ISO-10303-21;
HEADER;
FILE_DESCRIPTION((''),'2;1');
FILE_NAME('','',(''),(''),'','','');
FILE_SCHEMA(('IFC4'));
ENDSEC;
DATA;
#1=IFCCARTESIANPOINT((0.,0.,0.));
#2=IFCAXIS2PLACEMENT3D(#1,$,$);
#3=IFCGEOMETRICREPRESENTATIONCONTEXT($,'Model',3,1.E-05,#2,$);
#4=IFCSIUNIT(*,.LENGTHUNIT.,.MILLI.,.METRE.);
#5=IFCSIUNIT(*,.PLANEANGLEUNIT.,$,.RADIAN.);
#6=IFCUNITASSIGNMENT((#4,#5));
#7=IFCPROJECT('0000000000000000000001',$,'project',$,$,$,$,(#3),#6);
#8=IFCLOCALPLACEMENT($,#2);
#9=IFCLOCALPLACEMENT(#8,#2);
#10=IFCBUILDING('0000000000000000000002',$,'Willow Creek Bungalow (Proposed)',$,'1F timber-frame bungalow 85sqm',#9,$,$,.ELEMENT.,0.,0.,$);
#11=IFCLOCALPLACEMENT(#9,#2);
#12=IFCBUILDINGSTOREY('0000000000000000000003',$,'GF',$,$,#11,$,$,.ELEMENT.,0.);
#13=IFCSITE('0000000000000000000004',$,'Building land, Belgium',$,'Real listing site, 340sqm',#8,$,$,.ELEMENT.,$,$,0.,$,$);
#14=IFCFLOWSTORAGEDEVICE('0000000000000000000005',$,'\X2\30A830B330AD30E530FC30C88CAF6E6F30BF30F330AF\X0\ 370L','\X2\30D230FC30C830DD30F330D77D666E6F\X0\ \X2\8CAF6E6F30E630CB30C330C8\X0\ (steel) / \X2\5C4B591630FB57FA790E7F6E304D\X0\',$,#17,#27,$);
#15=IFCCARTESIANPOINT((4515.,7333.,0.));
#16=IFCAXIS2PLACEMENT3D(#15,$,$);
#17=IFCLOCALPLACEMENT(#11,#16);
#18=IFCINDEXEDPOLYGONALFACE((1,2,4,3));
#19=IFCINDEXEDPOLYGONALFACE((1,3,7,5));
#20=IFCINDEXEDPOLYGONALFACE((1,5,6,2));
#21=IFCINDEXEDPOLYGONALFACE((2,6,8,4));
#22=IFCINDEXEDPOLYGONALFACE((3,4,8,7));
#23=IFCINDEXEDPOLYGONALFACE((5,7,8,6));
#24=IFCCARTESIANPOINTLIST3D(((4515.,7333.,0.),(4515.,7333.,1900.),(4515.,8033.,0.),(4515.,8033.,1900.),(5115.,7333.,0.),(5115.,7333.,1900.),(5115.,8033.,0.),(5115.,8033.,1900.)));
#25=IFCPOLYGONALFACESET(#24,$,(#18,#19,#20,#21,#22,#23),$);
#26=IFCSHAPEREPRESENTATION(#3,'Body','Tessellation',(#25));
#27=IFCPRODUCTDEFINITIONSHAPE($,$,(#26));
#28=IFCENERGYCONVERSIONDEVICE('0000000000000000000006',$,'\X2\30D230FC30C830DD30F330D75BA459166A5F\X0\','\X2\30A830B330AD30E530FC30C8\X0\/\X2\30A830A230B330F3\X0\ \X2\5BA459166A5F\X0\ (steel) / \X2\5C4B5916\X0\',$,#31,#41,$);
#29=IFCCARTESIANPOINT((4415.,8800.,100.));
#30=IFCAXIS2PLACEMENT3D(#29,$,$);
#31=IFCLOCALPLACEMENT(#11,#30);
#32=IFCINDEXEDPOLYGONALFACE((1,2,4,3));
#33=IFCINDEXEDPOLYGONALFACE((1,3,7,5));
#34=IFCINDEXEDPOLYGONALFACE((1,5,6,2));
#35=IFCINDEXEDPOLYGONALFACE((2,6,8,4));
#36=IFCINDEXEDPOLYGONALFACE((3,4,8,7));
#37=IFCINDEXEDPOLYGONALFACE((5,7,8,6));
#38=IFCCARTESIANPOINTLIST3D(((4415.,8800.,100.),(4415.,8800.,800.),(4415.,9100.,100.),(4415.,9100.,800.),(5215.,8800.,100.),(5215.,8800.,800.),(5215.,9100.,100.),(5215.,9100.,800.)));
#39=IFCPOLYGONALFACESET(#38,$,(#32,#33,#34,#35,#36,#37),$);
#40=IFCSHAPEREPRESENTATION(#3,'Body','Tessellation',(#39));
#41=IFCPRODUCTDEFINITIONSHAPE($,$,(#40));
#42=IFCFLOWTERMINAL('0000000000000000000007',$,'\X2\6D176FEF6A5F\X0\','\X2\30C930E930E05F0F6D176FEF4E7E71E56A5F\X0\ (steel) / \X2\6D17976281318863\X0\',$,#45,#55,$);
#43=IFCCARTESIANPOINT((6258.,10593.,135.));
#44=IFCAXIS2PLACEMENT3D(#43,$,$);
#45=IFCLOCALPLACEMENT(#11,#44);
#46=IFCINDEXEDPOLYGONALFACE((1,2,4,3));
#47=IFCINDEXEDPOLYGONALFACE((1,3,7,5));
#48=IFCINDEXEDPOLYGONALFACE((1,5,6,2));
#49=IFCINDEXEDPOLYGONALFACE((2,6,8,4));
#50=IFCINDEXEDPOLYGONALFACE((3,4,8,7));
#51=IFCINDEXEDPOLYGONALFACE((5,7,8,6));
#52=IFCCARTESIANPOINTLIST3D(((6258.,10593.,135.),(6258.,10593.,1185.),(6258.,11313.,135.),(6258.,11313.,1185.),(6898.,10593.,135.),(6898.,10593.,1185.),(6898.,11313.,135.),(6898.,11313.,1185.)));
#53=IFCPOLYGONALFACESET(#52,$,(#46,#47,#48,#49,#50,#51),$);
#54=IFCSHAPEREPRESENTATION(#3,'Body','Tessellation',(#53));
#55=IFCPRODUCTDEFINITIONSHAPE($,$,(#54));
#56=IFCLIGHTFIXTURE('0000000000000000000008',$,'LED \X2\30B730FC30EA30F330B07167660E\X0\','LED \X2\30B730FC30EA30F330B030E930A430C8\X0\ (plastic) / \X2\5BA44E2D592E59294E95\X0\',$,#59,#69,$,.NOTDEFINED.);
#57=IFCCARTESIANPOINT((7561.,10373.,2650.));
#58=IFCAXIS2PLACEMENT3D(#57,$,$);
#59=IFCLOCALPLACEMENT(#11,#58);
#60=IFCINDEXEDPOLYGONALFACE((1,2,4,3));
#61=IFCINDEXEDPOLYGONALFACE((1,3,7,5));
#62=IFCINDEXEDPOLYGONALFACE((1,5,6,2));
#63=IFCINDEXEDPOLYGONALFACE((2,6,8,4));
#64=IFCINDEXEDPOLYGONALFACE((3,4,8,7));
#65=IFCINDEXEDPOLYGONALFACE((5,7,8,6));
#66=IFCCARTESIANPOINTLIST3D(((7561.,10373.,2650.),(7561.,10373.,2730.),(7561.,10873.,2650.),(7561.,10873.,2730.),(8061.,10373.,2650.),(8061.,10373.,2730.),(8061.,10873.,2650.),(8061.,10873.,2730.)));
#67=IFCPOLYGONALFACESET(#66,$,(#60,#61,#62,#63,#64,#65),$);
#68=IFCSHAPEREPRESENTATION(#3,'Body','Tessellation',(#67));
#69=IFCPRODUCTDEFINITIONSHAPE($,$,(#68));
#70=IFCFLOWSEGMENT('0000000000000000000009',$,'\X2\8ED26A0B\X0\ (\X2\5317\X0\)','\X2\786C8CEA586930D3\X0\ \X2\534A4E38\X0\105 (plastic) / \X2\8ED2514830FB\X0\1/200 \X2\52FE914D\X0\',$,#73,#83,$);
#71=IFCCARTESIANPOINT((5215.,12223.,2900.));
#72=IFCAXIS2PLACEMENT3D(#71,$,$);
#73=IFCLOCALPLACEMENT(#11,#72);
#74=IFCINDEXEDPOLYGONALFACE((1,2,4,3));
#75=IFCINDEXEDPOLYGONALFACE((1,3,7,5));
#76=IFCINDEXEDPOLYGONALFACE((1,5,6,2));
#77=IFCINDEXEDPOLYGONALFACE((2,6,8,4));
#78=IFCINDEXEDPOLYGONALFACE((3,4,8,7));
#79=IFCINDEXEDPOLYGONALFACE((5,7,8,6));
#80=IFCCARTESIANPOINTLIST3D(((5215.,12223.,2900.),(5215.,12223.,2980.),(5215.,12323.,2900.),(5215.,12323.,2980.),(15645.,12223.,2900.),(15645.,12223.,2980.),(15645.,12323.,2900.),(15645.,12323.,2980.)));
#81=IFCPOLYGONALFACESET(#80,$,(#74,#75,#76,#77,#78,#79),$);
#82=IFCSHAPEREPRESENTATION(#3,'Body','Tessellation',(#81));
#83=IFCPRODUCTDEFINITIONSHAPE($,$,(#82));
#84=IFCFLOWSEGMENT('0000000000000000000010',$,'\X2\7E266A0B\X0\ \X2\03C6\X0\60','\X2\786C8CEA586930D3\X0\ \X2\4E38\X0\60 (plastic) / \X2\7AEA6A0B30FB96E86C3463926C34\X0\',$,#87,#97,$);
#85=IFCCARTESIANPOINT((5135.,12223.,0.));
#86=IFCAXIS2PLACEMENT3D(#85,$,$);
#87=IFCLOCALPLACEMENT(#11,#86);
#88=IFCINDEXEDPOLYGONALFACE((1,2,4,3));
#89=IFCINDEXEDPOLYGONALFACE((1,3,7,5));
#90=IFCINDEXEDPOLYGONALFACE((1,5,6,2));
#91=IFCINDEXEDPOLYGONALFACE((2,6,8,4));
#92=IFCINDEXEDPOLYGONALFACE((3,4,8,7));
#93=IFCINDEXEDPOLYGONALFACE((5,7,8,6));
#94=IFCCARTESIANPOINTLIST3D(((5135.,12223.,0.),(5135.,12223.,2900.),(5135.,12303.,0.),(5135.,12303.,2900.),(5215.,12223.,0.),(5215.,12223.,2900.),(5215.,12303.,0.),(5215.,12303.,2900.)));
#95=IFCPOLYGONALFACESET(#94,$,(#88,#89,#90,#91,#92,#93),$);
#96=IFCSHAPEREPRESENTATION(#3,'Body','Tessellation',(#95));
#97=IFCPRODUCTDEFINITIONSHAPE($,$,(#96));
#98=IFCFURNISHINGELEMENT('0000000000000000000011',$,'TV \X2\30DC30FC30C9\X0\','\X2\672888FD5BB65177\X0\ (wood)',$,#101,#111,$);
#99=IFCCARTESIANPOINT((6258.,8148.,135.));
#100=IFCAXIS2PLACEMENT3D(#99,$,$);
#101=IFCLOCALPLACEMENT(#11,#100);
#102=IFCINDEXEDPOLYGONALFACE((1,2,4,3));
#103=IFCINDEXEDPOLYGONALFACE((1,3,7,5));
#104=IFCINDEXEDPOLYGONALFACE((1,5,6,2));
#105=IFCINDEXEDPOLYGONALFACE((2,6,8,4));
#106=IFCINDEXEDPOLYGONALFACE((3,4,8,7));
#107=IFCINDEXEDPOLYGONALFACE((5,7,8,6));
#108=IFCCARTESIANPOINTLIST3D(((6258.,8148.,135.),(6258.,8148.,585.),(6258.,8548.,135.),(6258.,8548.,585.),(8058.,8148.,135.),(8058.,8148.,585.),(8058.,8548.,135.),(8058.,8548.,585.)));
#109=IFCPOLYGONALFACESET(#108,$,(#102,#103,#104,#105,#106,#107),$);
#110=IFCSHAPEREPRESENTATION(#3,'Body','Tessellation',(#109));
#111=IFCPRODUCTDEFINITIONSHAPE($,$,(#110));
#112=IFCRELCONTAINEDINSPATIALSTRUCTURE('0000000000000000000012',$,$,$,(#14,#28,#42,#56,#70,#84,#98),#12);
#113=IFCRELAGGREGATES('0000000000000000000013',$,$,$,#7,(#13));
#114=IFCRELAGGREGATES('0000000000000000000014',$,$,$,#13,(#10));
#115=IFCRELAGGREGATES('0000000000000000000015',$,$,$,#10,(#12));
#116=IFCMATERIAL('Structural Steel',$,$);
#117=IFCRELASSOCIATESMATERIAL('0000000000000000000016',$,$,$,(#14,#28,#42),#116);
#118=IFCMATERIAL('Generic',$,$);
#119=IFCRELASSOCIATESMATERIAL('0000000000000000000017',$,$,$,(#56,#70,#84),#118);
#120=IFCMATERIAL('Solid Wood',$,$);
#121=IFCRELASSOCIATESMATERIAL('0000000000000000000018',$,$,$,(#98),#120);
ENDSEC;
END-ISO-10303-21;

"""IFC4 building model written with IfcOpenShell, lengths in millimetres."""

from ifc_helpers import new_model, si_unit, frame, frame_2d, origin, place, context, project, spatial, rectangle, extrude, material, element, save


model = new_model("IFC4")

# Units and contexts
model_context = context("Model", 3, precision=1e-05, world=origin())
ifc_project = project(units=[si_unit("LENGTHUNIT", "METRE", prefix="MILLI"), si_unit("PLANEANGLEUNIT", "RADIAN")], contexts=[model_context])

# Site, building, storey
site_placement = place(None, origin())
site = spatial("IfcSite", under=ifc_project, at=site_placement, Name="Building land, Belgium", ObjectType="Real listing site, 340sqm", CompositionType="ELEMENT", RefElevation=0.0)
building_placement = place(site_placement, origin())
building = spatial("IfcBuilding", under=site, at=building_placement, Name="Willow Creek Bungalow (Proposed)", ObjectType="1F timber-frame bungalow 85sqm", CompositionType="ELEMENT", ElevationOfRefHeight=0.0, ElevationOfTerrain=0.0)
storey_placement = place(building_placement, origin())
storey = spatial("IfcBuildingStorey", under=building, at=storey_placement, Name="GF", CompositionType="ELEMENT", Elevation=0.0)

# Shared definitions
ifc_material_1 = material(Name="Solid Wood")

# Shared definitions
ifc_material_2 = material(Name="Structural Steel")

# Shared definitions
ifc_material_3 = material(Name="Generic")

# Flow storage device
flow_storage_device_placement = place(storey_placement, frame((4515.0, 7333.0, 0.0)))
element("IfcFlowStorageDevice", 1, at=flow_storage_device_placement, inside=storey, material=ifc_material_2, Name="エコキュート貯湯タンク 370L", Description="ヒートポンプ給湯 貯湯ユニット (steel) / 屋外・基礎置き", context=model_context, shape_type="SweptSolid", body=[
    extrude(rectangle(XDim=600.0, YDim=700.0, at=frame_2d((300.0, 350.0))), frame((4515.0, 7333.0, 0.0)), (0.0, 0.0, 1.0), 1900.0),
])

# Energy conversion device
energy_conversion_device_placement = place(storey_placement, frame((4415.0, 8800.0, 100.0)))
element("IfcEnergyConversionDevice", 2, at=energy_conversion_device_placement, inside=storey, material=ifc_material_2, Name="ヒートポンプ室外機", Description="エコキュート/エアコン 室外機 (steel) / 屋外", context=model_context, shape_type="SweptSolid", body=[
    extrude(rectangle(XDim=800.0, YDim=300.0, at=frame_2d((400.0, 150.0))), frame((4415.0, 8800.0, 100.0)), (0.0, 0.0, 1.0), 700.0),
])

# Flow terminal
flow_terminal_placement = place(storey_placement, frame((6258.0, 10593.0, 135.0)))
element("IfcFlowTerminal", 3, at=flow_terminal_placement, inside=storey, material=ifc_material_2, Name="洗濯機", Description="ドラム式洗濯乾燥機 (steel) / 洗面脱衣", context=model_context, shape_type="SweptSolid", body=[
    extrude(rectangle(XDim=640.0, YDim=720.0, at=frame_2d((320.0, 360.0))), frame((6258.0, 10593.0, 135.0)), (0.0, 0.0, 1.0), 1050.0),
])

# Light fixture
light_fixture_placement = place(storey_placement, frame((7561.0, 10373.0, 2650.0)))
element("IfcLightFixture", 4, at=light_fixture_placement, inside=storey, material=ifc_material_3, Name="LED シーリング照明", Description="LED シーリングライト (plastic) / 室中央天井", PredefinedType="NOTDEFINED", context=model_context, shape_type="SweptSolid", body=[
    extrude(rectangle(XDim=500.0, YDim=500.0, at=frame_2d((250.0, 250.0))), frame((7561.0, 10373.0, 2650.0)), (0.0, 0.0, 1.0), 80.0),
])

# Flow segments
flow_segment_1_placement = place(storey_placement, frame((5215.0, 12223.0, 2900.0)))
element("IfcFlowSegment", 5, at=flow_segment_1_placement, inside=storey, material=ifc_material_3, Name="軒樋 (北)", Description="硬質塩ビ 半丸105 (plastic) / 軒先・1/200 勾配", context=model_context, shape_type="SweptSolid", body=[
    extrude(rectangle(XDim=10430.0, YDim=100.0, at=frame_2d((5215.0, 50.0))), frame((5215.0, 12223.0, 2900.0)), (0.0, 0.0, 1.0), 80.0),
])
flow_segment_2_placement = place(storey_placement, frame((5135.0, 12223.0, 0.0)))
element("IfcFlowSegment", 6, at=flow_segment_2_placement, inside=storey, material=ifc_material_3, Name="縦樋 φ60", Description="硬質塩ビ 丸60 (plastic) / 竪樋・雨水排水", context=model_context, shape_type="SweptSolid", body=[
    extrude(rectangle(XDim=80.0, YDim=80.0, at=frame_2d((40.0, 40.0))), frame((5135.0, 12223.0, 0.0)), (0.0, 0.0, 1.0), 2900.0),
])

# Furnishing element
furnishing_placement = place(storey_placement, frame((6258.0, 8148.0, 135.0)))
element("IfcFurnishingElement", 7, at=furnishing_placement, inside=storey, material=ifc_material_1, Name="TV ボード", Description="木製家具 (wood)", context=model_context, shape_type="SweptSolid", body=[
    extrude(rectangle(XDim=1800.0, YDim=400.0, at=frame_2d((900.0, 200.0))), frame((6258.0, 8148.0, 135.0)), (0.0, 0.0, 1.0), 450.0),
])

save(model, "model.ifc")
